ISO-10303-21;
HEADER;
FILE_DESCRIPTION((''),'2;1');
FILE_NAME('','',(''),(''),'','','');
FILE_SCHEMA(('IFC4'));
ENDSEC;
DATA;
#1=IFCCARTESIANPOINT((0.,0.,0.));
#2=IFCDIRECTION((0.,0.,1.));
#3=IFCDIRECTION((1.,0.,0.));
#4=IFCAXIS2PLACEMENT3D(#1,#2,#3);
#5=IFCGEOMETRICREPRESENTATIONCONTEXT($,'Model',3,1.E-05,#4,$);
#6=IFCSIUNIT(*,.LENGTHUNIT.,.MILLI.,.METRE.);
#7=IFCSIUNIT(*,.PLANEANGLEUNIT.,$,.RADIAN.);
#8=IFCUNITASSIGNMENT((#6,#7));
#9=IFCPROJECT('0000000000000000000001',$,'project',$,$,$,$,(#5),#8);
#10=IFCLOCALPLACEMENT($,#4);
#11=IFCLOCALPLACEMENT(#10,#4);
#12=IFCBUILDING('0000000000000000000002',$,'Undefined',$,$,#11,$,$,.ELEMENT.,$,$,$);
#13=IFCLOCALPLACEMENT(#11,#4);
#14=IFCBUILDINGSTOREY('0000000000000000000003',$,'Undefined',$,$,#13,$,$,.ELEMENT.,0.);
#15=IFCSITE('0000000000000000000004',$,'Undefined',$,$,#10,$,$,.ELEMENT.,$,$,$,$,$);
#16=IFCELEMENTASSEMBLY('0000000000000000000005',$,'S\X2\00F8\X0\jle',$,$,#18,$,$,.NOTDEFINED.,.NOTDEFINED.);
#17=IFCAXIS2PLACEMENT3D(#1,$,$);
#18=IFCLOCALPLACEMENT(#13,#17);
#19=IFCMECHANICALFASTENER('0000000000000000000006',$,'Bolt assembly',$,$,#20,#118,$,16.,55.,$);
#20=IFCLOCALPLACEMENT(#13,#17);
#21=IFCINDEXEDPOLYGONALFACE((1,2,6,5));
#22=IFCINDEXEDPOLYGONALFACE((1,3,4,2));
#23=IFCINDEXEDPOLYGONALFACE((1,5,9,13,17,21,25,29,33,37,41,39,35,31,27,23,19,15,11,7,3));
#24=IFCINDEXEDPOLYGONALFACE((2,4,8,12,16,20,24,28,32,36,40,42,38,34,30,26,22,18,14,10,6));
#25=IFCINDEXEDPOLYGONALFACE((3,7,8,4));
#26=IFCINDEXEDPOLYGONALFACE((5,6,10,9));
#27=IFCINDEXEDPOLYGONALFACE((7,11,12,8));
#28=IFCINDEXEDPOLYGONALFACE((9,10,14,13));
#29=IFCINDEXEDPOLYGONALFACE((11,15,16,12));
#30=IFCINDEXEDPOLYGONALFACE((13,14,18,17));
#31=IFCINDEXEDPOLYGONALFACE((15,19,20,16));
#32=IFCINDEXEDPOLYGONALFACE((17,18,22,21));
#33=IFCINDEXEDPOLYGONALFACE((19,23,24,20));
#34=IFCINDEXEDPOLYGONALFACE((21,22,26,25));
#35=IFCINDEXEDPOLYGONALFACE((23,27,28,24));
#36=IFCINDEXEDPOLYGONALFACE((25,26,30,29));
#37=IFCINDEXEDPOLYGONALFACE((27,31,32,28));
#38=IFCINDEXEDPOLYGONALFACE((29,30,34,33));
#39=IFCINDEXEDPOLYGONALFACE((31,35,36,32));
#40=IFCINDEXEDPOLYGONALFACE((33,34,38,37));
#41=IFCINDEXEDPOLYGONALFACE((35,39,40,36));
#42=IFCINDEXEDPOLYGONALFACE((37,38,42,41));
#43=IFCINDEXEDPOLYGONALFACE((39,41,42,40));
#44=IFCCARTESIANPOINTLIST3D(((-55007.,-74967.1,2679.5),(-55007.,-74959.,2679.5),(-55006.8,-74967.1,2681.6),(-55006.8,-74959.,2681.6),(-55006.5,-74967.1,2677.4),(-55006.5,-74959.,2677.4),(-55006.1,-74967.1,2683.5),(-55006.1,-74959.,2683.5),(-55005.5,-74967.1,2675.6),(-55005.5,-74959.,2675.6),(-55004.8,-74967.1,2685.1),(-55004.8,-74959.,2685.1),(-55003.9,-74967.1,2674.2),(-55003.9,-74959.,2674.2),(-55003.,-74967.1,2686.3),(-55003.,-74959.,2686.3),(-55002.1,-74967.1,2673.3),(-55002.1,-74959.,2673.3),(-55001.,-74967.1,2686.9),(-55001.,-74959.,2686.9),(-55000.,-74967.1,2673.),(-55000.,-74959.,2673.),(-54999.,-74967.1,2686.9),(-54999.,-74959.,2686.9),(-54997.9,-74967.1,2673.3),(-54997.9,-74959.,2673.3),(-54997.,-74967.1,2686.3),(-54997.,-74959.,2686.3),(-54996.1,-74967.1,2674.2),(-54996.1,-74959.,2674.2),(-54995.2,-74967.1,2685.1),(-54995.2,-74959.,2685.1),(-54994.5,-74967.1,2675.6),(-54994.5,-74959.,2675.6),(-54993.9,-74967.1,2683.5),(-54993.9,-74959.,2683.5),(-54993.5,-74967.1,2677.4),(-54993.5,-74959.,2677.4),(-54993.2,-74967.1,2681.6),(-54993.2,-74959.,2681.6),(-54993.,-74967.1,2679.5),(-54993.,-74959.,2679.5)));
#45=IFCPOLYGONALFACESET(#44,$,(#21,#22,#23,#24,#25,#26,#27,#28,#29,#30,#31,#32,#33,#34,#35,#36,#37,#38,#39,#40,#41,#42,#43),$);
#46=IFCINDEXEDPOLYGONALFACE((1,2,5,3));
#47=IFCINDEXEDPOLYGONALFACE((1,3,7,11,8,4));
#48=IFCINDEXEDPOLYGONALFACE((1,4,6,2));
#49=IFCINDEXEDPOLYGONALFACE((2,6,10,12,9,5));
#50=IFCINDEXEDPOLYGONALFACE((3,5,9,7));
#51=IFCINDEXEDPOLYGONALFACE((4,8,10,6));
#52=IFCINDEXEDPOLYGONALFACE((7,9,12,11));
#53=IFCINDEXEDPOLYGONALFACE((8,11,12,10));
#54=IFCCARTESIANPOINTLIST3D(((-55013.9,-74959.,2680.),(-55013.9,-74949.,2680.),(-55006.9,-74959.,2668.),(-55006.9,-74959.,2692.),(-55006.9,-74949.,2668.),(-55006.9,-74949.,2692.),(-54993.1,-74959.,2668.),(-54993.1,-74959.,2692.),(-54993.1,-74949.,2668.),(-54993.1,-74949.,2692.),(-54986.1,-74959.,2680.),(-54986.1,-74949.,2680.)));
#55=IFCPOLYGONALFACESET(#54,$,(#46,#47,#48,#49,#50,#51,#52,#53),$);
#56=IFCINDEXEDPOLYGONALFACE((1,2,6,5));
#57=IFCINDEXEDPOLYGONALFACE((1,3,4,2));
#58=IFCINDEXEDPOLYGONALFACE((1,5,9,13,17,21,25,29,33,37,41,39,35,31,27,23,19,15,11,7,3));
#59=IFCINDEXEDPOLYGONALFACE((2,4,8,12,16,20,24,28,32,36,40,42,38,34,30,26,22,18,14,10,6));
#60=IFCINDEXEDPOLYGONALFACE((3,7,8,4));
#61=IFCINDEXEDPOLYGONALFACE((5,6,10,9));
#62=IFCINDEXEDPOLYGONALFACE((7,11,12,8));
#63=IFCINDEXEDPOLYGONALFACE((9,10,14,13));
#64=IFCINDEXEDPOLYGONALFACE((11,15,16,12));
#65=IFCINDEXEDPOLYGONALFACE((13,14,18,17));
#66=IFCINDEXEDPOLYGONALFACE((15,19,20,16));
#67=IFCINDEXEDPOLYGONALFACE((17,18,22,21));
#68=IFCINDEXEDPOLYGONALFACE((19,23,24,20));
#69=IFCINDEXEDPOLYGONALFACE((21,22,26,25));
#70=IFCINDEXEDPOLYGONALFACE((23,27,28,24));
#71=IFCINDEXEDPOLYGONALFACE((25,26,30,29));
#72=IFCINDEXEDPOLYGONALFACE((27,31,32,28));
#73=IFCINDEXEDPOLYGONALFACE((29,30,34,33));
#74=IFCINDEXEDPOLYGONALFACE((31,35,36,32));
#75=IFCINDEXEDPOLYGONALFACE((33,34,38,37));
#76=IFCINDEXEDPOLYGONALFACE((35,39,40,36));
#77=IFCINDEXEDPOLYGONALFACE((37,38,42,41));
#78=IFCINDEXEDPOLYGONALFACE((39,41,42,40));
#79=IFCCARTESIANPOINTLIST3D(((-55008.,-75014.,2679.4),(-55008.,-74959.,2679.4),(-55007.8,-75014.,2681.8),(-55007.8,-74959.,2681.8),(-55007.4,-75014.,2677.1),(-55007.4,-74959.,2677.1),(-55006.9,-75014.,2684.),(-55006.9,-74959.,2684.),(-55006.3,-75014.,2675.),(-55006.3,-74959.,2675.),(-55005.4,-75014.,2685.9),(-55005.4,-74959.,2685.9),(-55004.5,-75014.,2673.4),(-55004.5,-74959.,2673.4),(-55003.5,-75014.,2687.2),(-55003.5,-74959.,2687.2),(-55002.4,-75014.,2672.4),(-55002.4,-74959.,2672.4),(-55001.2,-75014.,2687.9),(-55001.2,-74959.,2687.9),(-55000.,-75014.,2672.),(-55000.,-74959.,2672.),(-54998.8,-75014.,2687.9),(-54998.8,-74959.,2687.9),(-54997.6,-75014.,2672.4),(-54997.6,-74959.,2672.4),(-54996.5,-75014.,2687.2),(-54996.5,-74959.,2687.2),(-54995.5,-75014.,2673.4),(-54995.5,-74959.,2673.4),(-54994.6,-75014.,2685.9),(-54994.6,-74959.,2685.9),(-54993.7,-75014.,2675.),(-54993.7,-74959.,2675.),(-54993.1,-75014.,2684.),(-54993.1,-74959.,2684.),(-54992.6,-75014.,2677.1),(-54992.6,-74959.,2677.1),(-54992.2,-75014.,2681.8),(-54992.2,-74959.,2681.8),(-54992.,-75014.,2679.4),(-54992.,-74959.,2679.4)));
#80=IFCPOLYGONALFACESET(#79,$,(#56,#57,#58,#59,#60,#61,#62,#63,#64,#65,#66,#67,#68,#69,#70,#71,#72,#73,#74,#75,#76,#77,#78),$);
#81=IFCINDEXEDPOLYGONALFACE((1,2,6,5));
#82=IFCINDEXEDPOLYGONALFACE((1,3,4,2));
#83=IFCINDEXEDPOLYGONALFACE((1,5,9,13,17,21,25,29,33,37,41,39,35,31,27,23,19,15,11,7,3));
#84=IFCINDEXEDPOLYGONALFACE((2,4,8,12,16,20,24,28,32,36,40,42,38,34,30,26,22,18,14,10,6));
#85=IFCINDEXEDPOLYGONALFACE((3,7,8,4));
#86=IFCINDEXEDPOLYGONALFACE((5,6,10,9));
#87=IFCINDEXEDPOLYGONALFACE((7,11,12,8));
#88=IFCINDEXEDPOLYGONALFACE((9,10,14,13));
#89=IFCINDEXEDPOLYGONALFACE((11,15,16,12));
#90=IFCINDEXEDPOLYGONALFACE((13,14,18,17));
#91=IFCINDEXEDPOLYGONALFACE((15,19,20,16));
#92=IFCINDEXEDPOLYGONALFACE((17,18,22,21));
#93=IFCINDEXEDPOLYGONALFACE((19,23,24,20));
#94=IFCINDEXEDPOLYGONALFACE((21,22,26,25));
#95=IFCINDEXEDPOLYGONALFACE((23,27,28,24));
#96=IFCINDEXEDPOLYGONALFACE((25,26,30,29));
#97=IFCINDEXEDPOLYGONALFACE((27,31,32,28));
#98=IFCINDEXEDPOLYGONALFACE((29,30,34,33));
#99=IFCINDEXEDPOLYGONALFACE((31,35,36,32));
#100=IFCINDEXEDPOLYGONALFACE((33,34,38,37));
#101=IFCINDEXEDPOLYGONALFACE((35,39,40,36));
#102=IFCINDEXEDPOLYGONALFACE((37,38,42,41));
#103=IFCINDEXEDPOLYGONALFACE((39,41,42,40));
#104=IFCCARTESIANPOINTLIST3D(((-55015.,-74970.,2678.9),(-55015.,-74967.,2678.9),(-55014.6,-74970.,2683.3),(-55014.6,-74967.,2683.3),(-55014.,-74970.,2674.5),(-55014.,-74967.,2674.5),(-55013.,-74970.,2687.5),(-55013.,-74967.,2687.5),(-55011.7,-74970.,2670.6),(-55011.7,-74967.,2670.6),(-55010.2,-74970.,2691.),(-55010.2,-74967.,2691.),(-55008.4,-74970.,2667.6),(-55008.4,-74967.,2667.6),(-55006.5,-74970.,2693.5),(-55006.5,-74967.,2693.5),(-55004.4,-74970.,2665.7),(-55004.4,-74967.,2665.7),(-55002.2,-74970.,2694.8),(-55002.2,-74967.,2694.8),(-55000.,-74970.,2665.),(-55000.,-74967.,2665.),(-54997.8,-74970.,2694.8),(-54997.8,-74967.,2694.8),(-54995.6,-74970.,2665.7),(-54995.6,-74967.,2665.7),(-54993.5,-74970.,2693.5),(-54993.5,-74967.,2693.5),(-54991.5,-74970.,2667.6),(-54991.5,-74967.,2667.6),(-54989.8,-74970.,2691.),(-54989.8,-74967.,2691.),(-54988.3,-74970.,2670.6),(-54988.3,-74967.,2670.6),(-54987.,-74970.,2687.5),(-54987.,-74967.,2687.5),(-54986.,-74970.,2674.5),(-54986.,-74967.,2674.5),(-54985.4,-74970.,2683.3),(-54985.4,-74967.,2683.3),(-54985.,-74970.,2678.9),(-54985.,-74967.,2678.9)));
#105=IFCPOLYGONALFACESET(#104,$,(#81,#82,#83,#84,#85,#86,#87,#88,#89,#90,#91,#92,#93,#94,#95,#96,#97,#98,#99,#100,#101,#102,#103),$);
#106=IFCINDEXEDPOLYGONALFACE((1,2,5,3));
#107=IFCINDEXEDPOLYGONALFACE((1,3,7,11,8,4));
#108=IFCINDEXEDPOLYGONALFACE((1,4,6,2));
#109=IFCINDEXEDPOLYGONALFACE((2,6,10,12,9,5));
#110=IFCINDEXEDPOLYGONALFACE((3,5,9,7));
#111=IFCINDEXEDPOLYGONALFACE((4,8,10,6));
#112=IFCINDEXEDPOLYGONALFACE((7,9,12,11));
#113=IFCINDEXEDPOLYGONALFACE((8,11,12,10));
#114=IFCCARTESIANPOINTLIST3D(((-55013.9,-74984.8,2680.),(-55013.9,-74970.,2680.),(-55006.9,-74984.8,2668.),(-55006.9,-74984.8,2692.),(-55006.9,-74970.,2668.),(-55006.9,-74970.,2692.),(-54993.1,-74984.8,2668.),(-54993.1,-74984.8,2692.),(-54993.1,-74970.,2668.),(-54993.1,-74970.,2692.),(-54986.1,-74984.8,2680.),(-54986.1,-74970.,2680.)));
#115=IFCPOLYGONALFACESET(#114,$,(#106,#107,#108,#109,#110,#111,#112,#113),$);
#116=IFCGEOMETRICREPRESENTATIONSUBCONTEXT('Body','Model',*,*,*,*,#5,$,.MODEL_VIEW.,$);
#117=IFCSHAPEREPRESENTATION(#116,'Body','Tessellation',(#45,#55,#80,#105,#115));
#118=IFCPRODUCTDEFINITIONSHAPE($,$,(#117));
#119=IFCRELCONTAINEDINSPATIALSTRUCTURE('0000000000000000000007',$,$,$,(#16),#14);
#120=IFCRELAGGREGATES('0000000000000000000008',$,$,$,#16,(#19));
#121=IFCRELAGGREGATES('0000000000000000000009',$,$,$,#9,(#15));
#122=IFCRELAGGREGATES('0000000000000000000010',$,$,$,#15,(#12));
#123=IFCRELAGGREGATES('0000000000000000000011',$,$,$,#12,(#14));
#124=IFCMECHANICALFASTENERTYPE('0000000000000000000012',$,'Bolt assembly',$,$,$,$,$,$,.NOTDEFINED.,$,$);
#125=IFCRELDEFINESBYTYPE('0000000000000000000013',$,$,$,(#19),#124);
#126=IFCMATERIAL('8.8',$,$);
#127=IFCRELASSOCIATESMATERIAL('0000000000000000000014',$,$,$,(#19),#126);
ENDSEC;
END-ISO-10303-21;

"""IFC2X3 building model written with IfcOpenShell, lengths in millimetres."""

from ifc_helpers import new_model, si_unit, frame, origin_with_axes, origin_2d_with_axis, place, context, subcontext, project, spatial, polyline, circle, outline, extrude, source, transform, mapped, material, type_object, element, aggregate, save


model = new_model("IFC2X3")

# Units and contexts
model_context = context("Model", 3, precision=1e-05, world=origin_with_axes())
body_context = subcontext(model_context, "Body", "Model", "MODEL_VIEW")
ifc_project = project(units=[si_unit("LENGTHUNIT", "METRE", prefix="MILLI"), si_unit("PLANEANGLEUNIT", "RADIAN")], contexts=[model_context])

# Site, building, storey
site_placement = place(None, origin_with_axes())
site = spatial("IfcSite", under=ifc_project, at=site_placement, Name="Undefined", CompositionType="ELEMENT")
building_placement = place(site_placement, origin_with_axes())
building = spatial("IfcBuilding", under=site, at=building_placement, Name="Undefined", CompositionType="ELEMENT")
storey_placement = place(building_placement, origin_with_axes())
storey = spatial("IfcBuildingStorey", under=building, at=storey_placement, Name="Undefined", CompositionType="ELEMENT", Elevation=0.0)

# Element assembly
assembly_1_placement = place(storey_placement, origin_with_axes())
assembly_1 = element("IfcElementAssembly", 1, at=assembly_1_placement, inside=storey, Name="Søjle", AssemblyPlace="NOTDEFINED", PredefinedType="NOTDEFINED")

# Mechanical fastener
ifc_material_1 = material(Name="8.8")
mechanical_fastener_type = type_object("IfcMechanicalFastenerType", Name="Bolt assembly")
shared_shape_1 = source(origin_with_axes(), body_context, "Body", "SweptSolid", [
    extrude(circle(Radius=7.0, at=origin_2d_with_axis()), frame((0.0, 0.0, 0.0), z_axis=(0.0, 1.0, 0.0), x_axis=(1.0, 0.0, 0.0)), (0.0, 0.0, 1.0), 8.1),
    extrude(outline(polyline([(12.0, -6.9), (12.0, 6.9), (0.0, 13.9), (-12.0, 6.9), (-12.0, -6.9), (0.0, -13.9), (12.0, -6.9)])), frame((0.0, -10.0, 0.0), z_axis=(0.0, 1.0, 0.0), x_axis=(1.0, 0.0, 0.0)), (0.0, 0.0, 1.0), 10.0),
    extrude(circle(Radius=8.0, at=origin_2d_with_axis()), frame((0.0, 0.0, 0.0), z_axis=(0.0, 1.0, 0.0), x_axis=(1.0, 0.0, 0.0)), (0.0, 0.0, 1.0), 55.0),
    extrude(circle(Radius=15.0, at=origin_2d_with_axis()), frame((0.0, 8.0, 0.0), z_axis=(0.0, 1.0, 0.0), x_axis=(1.0, 0.0, 0.0)), (0.0, 0.0, 1.0), 3.0),
    extrude(outline(polyline([(12.0, -6.9), (12.0, 6.9), (0.0, 13.9), (-12.0, 6.9), (-12.0, -6.9), (0.0, -13.9), (12.0, -6.9)])), frame((0.0, 11.0, 0.0), z_axis=(0.0, 1.0, 0.0), x_axis=(1.0, 0.0, 0.0)), (0.0, 0.0, 1.0), 14.8),
])
mechanical_fastener_1_placement = place(assembly_1_placement, frame((-55000.0, -74959.0, 2680.0), z_axis=(-1.0, 0.0, 0.0), x_axis=(0.0, 0.0, -1.0)))
mechanical_fastener_1 = element("IfcMechanicalFastener", 2, at=mechanical_fastener_1_placement, type_object=mechanical_fastener_type, material=ifc_material_1, Name="Bolt assembly", NominalDiameter=16.0, NominalLength=55.0, context=body_context, shape_type="MappedRepresentation", body=[
    mapped(shared_shape_1, transform((0.0, 0.0, 0.0))),
])
aggregate(assembly_1, [mechanical_fastener_1])

save(model, "model.ifc")
